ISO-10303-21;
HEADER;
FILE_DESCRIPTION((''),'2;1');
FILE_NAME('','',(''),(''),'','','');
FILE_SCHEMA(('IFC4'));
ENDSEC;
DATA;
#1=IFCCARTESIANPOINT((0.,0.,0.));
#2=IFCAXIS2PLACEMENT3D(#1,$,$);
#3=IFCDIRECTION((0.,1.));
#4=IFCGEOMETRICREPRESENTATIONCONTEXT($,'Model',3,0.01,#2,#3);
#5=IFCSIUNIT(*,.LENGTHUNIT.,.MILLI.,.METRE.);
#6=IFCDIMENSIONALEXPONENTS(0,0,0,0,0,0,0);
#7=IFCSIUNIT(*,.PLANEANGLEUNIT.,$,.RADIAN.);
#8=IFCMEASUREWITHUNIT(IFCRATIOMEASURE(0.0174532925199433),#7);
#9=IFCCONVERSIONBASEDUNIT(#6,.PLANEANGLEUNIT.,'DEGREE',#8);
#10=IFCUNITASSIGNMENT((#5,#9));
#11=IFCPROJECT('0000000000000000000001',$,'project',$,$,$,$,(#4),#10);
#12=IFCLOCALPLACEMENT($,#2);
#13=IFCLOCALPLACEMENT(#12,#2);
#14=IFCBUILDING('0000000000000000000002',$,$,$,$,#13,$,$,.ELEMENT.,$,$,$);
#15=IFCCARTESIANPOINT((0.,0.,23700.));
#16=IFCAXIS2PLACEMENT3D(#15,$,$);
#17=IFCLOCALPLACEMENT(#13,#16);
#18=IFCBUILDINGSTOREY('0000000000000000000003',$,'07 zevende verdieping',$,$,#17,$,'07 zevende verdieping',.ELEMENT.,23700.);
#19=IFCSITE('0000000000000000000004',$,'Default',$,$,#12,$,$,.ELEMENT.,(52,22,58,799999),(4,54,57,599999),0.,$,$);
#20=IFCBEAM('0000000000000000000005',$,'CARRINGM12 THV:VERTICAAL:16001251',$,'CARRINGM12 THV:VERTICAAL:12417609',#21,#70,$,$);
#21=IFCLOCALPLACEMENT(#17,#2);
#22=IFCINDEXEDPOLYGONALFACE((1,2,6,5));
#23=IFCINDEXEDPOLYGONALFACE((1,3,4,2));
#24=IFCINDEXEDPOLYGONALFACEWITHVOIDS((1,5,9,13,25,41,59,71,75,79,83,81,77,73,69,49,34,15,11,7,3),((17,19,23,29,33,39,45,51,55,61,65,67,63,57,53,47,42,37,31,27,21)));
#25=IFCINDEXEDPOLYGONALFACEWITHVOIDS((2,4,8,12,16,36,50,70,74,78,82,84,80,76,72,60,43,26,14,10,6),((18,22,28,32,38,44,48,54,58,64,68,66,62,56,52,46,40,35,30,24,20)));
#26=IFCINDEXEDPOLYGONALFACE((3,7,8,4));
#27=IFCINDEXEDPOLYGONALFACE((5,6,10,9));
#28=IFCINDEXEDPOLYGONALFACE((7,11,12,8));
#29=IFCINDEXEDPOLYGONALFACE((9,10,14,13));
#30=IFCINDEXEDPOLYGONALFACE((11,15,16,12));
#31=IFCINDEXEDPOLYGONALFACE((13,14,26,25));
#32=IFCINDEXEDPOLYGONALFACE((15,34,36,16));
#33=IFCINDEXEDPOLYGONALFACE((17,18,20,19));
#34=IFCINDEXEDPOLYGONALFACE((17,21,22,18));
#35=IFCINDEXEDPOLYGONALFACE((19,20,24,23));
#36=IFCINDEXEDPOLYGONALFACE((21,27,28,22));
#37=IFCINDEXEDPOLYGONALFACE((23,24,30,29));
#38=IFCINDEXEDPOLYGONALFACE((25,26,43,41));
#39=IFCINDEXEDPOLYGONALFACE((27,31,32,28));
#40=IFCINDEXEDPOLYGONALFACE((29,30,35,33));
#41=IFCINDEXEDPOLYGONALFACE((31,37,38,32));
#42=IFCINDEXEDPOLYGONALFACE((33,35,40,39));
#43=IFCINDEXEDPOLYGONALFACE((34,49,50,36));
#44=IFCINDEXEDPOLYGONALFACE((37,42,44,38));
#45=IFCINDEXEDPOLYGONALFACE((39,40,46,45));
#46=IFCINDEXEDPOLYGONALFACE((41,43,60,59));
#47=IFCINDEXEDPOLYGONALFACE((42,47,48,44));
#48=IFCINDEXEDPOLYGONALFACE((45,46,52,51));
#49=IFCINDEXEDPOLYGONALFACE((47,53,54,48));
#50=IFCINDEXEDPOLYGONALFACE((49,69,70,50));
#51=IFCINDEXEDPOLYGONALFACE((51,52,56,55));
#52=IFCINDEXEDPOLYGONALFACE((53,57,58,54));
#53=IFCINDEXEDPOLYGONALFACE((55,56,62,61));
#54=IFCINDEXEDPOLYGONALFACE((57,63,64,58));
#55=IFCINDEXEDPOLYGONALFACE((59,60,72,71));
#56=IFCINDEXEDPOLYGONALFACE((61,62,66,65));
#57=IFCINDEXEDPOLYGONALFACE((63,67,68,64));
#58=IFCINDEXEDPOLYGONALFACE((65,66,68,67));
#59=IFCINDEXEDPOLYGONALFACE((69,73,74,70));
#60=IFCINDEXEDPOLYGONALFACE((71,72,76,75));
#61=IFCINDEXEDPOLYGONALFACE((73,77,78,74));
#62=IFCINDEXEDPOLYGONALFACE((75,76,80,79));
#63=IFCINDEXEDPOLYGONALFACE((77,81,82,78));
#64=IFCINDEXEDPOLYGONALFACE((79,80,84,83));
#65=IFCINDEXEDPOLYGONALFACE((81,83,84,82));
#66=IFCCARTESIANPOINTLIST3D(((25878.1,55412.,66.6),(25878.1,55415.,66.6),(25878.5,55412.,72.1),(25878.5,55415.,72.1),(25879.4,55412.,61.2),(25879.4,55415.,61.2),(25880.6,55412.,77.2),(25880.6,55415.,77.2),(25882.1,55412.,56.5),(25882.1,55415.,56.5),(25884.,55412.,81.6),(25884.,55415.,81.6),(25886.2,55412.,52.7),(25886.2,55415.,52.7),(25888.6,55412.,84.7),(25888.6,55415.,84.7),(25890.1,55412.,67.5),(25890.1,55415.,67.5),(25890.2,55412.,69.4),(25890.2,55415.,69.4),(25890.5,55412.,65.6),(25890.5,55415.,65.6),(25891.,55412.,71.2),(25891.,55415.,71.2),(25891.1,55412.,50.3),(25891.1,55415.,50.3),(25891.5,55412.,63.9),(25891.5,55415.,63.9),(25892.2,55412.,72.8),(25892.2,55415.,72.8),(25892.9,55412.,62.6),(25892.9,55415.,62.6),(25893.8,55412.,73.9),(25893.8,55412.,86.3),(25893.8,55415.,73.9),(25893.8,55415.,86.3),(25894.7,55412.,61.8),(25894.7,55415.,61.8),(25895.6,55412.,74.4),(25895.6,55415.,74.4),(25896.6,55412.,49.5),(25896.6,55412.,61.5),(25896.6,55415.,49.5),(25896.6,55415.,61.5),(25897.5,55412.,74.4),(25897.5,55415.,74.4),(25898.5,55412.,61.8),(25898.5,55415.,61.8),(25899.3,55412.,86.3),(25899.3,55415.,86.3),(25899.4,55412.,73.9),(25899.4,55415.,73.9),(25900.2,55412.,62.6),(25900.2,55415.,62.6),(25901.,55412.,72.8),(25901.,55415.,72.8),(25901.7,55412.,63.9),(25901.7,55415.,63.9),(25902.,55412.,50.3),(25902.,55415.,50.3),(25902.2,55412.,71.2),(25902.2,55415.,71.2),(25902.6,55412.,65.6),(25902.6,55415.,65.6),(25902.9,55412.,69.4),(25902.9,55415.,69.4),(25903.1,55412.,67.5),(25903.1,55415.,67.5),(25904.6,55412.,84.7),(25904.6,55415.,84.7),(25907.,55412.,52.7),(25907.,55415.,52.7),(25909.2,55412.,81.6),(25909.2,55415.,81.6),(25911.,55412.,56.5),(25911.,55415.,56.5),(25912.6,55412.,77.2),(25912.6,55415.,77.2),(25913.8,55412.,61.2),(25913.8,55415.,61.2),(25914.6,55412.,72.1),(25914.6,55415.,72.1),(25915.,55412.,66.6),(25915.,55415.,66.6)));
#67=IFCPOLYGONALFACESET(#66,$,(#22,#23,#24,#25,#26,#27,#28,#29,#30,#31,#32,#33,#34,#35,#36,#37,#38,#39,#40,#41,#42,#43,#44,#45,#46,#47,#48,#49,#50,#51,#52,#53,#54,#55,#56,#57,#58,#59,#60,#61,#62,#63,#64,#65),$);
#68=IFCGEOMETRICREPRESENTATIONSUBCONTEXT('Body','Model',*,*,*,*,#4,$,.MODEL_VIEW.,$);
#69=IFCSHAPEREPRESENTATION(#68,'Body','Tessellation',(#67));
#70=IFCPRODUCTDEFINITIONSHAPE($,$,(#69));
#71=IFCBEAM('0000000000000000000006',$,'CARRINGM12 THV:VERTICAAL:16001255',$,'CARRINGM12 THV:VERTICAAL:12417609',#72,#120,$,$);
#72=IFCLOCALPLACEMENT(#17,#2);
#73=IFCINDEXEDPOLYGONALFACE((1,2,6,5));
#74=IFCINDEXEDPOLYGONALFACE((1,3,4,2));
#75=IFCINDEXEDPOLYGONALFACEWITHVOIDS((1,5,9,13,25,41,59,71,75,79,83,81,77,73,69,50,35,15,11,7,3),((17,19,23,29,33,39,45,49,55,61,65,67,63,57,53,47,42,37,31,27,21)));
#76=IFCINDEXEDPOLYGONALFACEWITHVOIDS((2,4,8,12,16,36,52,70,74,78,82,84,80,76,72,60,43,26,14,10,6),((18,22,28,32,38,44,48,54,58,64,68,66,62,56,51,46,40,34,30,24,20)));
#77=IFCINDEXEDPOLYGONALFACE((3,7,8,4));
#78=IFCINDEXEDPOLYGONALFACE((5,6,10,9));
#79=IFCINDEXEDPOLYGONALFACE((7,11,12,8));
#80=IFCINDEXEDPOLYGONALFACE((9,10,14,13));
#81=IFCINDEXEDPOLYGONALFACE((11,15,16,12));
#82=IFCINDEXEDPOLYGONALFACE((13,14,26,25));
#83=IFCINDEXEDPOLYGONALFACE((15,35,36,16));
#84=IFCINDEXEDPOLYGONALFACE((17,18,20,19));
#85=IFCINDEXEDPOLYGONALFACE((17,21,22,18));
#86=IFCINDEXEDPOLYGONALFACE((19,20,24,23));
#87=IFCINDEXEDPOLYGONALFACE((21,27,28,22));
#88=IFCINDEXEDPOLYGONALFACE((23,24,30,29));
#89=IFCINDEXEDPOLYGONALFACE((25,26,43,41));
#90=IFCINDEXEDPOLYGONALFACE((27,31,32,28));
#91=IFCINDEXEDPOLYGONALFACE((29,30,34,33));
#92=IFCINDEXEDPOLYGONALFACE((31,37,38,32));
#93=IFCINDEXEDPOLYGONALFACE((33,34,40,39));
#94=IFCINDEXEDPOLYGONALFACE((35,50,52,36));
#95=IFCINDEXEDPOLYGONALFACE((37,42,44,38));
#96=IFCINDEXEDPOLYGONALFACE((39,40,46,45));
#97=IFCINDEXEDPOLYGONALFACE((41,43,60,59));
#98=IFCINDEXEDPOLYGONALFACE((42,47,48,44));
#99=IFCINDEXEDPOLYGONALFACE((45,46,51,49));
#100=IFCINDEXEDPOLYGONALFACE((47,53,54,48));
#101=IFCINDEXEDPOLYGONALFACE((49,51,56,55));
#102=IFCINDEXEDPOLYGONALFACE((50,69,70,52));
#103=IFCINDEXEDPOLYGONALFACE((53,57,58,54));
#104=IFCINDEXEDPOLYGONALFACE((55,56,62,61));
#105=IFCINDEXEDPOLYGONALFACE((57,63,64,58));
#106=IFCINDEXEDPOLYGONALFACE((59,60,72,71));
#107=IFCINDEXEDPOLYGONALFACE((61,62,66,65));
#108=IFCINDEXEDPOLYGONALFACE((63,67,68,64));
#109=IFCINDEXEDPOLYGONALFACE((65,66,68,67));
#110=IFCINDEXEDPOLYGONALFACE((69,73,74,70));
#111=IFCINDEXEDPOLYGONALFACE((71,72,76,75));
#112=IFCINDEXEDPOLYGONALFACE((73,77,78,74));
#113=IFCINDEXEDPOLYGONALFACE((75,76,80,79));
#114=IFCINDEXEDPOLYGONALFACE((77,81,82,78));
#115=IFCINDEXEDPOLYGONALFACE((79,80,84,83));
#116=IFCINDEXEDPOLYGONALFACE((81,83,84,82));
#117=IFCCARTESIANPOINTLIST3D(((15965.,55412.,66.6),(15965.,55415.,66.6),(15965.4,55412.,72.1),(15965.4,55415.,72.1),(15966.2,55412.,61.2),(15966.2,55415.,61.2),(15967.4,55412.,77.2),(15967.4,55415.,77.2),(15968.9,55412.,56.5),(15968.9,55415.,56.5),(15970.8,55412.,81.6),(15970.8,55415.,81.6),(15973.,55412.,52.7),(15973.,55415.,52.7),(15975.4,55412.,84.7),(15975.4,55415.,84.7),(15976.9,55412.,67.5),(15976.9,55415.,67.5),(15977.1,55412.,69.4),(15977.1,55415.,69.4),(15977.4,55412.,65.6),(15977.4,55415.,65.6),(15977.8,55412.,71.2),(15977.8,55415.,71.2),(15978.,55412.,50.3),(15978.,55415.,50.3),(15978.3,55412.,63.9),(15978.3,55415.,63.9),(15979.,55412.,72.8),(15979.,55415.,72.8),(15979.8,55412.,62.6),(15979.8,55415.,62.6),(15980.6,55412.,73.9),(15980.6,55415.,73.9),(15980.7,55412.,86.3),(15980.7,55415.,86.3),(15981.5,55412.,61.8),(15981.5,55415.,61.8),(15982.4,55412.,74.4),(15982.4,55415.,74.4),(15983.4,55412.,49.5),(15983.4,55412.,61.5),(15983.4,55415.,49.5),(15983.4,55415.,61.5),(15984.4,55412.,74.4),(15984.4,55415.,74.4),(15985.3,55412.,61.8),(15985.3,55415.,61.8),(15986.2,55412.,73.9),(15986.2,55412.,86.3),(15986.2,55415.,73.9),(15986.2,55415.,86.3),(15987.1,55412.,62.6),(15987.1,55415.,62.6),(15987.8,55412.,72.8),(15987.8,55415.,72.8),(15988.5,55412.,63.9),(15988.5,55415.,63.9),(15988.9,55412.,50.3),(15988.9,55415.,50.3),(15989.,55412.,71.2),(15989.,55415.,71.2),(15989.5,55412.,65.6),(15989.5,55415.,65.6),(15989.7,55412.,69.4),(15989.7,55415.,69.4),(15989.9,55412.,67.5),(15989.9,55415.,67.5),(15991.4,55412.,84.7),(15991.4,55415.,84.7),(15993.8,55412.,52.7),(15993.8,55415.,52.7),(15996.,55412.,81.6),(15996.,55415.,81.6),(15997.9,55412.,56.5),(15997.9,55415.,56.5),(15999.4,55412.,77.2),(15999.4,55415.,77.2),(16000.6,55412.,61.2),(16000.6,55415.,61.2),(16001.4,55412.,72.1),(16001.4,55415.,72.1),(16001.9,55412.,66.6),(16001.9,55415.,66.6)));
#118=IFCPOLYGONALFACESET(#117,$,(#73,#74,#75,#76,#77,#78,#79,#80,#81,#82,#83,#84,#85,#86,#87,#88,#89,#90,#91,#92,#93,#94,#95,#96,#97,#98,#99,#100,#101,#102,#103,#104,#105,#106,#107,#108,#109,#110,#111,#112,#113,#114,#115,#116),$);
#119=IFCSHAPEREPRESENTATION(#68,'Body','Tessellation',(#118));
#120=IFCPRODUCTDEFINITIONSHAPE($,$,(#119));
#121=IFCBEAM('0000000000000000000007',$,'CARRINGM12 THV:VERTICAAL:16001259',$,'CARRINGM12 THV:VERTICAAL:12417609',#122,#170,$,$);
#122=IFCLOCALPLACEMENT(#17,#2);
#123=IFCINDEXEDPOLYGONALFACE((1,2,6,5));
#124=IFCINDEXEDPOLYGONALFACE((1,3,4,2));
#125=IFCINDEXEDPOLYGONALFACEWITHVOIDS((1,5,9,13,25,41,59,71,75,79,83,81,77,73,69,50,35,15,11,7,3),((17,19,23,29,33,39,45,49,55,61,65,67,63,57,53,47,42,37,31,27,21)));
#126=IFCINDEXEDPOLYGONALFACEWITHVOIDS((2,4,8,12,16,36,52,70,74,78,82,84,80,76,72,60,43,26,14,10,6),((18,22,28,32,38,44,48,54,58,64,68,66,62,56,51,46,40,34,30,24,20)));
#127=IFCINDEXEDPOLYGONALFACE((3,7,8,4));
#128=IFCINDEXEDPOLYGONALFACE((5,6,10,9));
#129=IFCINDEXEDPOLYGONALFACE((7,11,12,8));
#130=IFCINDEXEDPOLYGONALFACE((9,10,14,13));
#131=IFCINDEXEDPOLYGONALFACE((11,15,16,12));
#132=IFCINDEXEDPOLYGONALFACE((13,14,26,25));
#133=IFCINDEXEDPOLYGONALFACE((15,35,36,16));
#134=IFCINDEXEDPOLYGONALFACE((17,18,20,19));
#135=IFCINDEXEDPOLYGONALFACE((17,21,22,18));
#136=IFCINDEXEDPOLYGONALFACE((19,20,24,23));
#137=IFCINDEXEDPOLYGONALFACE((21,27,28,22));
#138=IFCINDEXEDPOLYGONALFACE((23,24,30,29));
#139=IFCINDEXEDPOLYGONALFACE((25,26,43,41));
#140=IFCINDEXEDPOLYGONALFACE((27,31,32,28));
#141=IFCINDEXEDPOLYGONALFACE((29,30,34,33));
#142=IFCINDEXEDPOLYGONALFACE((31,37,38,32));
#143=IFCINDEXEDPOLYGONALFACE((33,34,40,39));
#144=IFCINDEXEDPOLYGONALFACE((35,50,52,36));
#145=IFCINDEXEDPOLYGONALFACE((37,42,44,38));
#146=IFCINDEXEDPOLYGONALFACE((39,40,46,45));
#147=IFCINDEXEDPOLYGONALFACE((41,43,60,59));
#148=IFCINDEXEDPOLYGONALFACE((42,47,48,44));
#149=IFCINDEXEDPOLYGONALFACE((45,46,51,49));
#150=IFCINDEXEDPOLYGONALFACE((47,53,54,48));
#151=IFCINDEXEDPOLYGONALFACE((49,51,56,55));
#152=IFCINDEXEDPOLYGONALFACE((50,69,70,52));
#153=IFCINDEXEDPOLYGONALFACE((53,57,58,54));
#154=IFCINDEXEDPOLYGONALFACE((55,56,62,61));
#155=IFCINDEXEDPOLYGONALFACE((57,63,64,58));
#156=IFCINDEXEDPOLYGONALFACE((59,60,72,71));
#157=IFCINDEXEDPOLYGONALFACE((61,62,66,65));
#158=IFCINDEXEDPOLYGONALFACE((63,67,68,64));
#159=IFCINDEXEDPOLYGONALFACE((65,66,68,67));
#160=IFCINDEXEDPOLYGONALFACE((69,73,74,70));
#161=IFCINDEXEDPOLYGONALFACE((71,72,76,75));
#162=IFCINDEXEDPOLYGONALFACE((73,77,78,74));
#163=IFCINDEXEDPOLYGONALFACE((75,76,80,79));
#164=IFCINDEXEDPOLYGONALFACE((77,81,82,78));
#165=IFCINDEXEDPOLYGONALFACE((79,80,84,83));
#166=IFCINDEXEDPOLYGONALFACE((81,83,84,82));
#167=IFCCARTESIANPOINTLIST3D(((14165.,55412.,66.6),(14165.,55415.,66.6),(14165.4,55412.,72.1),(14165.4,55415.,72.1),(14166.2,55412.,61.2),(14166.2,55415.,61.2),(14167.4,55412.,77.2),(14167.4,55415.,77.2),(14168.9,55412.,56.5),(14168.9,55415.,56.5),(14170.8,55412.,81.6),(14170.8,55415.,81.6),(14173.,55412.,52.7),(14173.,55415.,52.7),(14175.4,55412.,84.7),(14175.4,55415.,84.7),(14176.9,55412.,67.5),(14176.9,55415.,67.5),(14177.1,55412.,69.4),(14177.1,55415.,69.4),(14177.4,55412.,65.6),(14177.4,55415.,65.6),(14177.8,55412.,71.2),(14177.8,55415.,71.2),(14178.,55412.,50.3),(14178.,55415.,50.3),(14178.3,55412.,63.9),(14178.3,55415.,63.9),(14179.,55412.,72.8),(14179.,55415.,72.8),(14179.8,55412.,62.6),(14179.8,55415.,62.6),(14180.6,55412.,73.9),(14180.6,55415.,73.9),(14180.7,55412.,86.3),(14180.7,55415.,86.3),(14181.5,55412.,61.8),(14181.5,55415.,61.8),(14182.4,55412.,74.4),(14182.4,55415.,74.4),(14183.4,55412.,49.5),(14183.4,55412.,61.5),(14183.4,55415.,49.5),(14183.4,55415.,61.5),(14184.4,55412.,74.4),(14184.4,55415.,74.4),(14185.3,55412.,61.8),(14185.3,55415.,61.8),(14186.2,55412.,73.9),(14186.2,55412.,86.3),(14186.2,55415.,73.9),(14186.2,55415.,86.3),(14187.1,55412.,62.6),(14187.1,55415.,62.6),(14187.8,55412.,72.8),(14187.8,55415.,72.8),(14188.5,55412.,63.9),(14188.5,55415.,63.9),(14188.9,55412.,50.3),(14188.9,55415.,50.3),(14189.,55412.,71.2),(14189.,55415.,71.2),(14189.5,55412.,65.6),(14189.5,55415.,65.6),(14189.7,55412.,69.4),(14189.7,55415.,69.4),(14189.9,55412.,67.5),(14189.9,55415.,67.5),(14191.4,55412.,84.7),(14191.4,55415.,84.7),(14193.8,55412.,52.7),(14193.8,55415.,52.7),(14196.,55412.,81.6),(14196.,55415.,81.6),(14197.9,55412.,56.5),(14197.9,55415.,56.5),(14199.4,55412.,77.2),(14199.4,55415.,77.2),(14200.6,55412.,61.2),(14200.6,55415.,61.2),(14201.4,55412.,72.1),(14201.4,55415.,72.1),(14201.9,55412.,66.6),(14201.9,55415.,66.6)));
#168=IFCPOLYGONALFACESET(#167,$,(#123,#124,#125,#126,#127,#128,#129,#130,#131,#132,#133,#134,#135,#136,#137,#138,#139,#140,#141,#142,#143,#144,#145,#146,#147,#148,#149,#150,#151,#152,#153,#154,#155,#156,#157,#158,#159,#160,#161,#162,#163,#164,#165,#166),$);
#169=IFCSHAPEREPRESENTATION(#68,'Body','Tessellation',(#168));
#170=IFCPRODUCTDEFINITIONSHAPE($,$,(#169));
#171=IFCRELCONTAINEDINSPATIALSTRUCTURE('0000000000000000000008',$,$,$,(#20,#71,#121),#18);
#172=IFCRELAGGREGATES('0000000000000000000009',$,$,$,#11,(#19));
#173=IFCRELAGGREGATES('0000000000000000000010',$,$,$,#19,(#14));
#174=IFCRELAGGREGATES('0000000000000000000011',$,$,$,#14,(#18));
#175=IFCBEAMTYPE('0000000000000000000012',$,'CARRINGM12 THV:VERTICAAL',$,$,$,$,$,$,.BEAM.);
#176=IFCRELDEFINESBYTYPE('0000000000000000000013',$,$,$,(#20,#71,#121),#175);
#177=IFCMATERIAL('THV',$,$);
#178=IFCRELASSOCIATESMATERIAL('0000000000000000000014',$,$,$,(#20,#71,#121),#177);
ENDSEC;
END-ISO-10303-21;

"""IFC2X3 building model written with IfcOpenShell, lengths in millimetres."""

from ifc_helpers import new_model, entity, si_unit, converted_unit, direction, frame, origin, origin_2d_with_axis, place, context, subcontext, project, spatial, hollow_circle, extrude, material, type_object, element, save


model = new_model("IFC2X3")

# Units and contexts
model_context = context("Model", 3, precision=0.01, world=origin(), true_north=direction((0.0, 1.0)))
body_context = subcontext(model_context, "Body", "Model", "MODEL_VIEW")
ifc_project = project(units=[si_unit("LENGTHUNIT", "METRE", prefix="MILLI"), converted_unit("PLANEANGLEUNIT", "DEGREE", entity("IfcRatioMeasure", 0.0174532925199433), si_unit("PLANEANGLEUNIT", "RADIAN"), dimensions=[0, 0, 0, 0, 0, 0, 0])], contexts=[model_context])

# Site, building, storey
site_placement = place(None, origin())
site = spatial("IfcSite", under=ifc_project, at=site_placement, Name="Default", CompositionType="ELEMENT", RefLatitude=(52, 22, 58, 799999), RefLongitude=(4, 54, 57, 599999), RefElevation=0.0)
building_placement = place(site_placement, origin())
building = spatial("IfcBuilding", under=site, at=building_placement, CompositionType="ELEMENT")
storey_placement = place(building_placement, frame((0.0, 0.0, 23700.0)))
storey = spatial("IfcBuildingStorey", under=building, at=storey_placement, Name="07 zevende verdieping", LongName="07 zevende verdieping", CompositionType="ELEMENT", Elevation=23700.0)

# Beams
ifc_material = material(Name="THV")
beam_type = type_object("IfcBeamType", Name="CARRINGM12 THV:VERTICAAL", PredefinedType="BEAM")
beam_1_placement = place(storey_placement, origin())
element("IfcBeam", 1, at=beam_1_placement, inside=storey, type_object=beam_type, material=ifc_material, Name="CARRINGM12 THV:VERTICAAL:16001251", ObjectType="CARRINGM12 THV:VERTICAAL:12417609", context=body_context, shape_type="SweptSolid", body=[
    extrude(hollow_circle(Radius=18.5, WallThickness=12.0, at=origin_2d_with_axis()), frame((25896.6, 55412.0, 68.0), z_axis=(0.0, 1.0, 0.0), x_axis=(0.0, 0.0, -1.0)), (0.0, 0.0, 1.0), 3.0),
])
beam_2_placement = place(storey_placement, origin())
element("IfcBeam", 2, at=beam_2_placement, inside=storey, type_object=beam_type, material=ifc_material, Name="CARRINGM12 THV:VERTICAAL:16001255", ObjectType="CARRINGM12 THV:VERTICAAL:12417609", context=body_context, shape_type="SweptSolid", body=[
    extrude(hollow_circle(Radius=18.5, WallThickness=12.0, at=origin_2d_with_axis()), frame((15983.4, 55412.0, 68.0), z_axis=(0.0, 1.0, 0.0), x_axis=(0.0, 0.0, -1.0)), (0.0, 0.0, 1.0), 3.0),
])
beam_3_placement = place(storey_placement, origin())
element("IfcBeam", 3, at=beam_3_placement, inside=storey, type_object=beam_type, material=ifc_material, Name="CARRINGM12 THV:VERTICAAL:16001259", ObjectType="CARRINGM12 THV:VERTICAAL:12417609", context=body_context, shape_type="SweptSolid", body=[
    extrude(hollow_circle(Radius=18.5, WallThickness=12.0, at=origin_2d_with_axis()), frame((14183.4, 55412.0, 68.0), z_axis=(0.0, 1.0, 0.0), x_axis=(0.0, 0.0, -1.0)), (0.0, 0.0, 1.0), 3.0),
])

save(model, "model.ifc")
